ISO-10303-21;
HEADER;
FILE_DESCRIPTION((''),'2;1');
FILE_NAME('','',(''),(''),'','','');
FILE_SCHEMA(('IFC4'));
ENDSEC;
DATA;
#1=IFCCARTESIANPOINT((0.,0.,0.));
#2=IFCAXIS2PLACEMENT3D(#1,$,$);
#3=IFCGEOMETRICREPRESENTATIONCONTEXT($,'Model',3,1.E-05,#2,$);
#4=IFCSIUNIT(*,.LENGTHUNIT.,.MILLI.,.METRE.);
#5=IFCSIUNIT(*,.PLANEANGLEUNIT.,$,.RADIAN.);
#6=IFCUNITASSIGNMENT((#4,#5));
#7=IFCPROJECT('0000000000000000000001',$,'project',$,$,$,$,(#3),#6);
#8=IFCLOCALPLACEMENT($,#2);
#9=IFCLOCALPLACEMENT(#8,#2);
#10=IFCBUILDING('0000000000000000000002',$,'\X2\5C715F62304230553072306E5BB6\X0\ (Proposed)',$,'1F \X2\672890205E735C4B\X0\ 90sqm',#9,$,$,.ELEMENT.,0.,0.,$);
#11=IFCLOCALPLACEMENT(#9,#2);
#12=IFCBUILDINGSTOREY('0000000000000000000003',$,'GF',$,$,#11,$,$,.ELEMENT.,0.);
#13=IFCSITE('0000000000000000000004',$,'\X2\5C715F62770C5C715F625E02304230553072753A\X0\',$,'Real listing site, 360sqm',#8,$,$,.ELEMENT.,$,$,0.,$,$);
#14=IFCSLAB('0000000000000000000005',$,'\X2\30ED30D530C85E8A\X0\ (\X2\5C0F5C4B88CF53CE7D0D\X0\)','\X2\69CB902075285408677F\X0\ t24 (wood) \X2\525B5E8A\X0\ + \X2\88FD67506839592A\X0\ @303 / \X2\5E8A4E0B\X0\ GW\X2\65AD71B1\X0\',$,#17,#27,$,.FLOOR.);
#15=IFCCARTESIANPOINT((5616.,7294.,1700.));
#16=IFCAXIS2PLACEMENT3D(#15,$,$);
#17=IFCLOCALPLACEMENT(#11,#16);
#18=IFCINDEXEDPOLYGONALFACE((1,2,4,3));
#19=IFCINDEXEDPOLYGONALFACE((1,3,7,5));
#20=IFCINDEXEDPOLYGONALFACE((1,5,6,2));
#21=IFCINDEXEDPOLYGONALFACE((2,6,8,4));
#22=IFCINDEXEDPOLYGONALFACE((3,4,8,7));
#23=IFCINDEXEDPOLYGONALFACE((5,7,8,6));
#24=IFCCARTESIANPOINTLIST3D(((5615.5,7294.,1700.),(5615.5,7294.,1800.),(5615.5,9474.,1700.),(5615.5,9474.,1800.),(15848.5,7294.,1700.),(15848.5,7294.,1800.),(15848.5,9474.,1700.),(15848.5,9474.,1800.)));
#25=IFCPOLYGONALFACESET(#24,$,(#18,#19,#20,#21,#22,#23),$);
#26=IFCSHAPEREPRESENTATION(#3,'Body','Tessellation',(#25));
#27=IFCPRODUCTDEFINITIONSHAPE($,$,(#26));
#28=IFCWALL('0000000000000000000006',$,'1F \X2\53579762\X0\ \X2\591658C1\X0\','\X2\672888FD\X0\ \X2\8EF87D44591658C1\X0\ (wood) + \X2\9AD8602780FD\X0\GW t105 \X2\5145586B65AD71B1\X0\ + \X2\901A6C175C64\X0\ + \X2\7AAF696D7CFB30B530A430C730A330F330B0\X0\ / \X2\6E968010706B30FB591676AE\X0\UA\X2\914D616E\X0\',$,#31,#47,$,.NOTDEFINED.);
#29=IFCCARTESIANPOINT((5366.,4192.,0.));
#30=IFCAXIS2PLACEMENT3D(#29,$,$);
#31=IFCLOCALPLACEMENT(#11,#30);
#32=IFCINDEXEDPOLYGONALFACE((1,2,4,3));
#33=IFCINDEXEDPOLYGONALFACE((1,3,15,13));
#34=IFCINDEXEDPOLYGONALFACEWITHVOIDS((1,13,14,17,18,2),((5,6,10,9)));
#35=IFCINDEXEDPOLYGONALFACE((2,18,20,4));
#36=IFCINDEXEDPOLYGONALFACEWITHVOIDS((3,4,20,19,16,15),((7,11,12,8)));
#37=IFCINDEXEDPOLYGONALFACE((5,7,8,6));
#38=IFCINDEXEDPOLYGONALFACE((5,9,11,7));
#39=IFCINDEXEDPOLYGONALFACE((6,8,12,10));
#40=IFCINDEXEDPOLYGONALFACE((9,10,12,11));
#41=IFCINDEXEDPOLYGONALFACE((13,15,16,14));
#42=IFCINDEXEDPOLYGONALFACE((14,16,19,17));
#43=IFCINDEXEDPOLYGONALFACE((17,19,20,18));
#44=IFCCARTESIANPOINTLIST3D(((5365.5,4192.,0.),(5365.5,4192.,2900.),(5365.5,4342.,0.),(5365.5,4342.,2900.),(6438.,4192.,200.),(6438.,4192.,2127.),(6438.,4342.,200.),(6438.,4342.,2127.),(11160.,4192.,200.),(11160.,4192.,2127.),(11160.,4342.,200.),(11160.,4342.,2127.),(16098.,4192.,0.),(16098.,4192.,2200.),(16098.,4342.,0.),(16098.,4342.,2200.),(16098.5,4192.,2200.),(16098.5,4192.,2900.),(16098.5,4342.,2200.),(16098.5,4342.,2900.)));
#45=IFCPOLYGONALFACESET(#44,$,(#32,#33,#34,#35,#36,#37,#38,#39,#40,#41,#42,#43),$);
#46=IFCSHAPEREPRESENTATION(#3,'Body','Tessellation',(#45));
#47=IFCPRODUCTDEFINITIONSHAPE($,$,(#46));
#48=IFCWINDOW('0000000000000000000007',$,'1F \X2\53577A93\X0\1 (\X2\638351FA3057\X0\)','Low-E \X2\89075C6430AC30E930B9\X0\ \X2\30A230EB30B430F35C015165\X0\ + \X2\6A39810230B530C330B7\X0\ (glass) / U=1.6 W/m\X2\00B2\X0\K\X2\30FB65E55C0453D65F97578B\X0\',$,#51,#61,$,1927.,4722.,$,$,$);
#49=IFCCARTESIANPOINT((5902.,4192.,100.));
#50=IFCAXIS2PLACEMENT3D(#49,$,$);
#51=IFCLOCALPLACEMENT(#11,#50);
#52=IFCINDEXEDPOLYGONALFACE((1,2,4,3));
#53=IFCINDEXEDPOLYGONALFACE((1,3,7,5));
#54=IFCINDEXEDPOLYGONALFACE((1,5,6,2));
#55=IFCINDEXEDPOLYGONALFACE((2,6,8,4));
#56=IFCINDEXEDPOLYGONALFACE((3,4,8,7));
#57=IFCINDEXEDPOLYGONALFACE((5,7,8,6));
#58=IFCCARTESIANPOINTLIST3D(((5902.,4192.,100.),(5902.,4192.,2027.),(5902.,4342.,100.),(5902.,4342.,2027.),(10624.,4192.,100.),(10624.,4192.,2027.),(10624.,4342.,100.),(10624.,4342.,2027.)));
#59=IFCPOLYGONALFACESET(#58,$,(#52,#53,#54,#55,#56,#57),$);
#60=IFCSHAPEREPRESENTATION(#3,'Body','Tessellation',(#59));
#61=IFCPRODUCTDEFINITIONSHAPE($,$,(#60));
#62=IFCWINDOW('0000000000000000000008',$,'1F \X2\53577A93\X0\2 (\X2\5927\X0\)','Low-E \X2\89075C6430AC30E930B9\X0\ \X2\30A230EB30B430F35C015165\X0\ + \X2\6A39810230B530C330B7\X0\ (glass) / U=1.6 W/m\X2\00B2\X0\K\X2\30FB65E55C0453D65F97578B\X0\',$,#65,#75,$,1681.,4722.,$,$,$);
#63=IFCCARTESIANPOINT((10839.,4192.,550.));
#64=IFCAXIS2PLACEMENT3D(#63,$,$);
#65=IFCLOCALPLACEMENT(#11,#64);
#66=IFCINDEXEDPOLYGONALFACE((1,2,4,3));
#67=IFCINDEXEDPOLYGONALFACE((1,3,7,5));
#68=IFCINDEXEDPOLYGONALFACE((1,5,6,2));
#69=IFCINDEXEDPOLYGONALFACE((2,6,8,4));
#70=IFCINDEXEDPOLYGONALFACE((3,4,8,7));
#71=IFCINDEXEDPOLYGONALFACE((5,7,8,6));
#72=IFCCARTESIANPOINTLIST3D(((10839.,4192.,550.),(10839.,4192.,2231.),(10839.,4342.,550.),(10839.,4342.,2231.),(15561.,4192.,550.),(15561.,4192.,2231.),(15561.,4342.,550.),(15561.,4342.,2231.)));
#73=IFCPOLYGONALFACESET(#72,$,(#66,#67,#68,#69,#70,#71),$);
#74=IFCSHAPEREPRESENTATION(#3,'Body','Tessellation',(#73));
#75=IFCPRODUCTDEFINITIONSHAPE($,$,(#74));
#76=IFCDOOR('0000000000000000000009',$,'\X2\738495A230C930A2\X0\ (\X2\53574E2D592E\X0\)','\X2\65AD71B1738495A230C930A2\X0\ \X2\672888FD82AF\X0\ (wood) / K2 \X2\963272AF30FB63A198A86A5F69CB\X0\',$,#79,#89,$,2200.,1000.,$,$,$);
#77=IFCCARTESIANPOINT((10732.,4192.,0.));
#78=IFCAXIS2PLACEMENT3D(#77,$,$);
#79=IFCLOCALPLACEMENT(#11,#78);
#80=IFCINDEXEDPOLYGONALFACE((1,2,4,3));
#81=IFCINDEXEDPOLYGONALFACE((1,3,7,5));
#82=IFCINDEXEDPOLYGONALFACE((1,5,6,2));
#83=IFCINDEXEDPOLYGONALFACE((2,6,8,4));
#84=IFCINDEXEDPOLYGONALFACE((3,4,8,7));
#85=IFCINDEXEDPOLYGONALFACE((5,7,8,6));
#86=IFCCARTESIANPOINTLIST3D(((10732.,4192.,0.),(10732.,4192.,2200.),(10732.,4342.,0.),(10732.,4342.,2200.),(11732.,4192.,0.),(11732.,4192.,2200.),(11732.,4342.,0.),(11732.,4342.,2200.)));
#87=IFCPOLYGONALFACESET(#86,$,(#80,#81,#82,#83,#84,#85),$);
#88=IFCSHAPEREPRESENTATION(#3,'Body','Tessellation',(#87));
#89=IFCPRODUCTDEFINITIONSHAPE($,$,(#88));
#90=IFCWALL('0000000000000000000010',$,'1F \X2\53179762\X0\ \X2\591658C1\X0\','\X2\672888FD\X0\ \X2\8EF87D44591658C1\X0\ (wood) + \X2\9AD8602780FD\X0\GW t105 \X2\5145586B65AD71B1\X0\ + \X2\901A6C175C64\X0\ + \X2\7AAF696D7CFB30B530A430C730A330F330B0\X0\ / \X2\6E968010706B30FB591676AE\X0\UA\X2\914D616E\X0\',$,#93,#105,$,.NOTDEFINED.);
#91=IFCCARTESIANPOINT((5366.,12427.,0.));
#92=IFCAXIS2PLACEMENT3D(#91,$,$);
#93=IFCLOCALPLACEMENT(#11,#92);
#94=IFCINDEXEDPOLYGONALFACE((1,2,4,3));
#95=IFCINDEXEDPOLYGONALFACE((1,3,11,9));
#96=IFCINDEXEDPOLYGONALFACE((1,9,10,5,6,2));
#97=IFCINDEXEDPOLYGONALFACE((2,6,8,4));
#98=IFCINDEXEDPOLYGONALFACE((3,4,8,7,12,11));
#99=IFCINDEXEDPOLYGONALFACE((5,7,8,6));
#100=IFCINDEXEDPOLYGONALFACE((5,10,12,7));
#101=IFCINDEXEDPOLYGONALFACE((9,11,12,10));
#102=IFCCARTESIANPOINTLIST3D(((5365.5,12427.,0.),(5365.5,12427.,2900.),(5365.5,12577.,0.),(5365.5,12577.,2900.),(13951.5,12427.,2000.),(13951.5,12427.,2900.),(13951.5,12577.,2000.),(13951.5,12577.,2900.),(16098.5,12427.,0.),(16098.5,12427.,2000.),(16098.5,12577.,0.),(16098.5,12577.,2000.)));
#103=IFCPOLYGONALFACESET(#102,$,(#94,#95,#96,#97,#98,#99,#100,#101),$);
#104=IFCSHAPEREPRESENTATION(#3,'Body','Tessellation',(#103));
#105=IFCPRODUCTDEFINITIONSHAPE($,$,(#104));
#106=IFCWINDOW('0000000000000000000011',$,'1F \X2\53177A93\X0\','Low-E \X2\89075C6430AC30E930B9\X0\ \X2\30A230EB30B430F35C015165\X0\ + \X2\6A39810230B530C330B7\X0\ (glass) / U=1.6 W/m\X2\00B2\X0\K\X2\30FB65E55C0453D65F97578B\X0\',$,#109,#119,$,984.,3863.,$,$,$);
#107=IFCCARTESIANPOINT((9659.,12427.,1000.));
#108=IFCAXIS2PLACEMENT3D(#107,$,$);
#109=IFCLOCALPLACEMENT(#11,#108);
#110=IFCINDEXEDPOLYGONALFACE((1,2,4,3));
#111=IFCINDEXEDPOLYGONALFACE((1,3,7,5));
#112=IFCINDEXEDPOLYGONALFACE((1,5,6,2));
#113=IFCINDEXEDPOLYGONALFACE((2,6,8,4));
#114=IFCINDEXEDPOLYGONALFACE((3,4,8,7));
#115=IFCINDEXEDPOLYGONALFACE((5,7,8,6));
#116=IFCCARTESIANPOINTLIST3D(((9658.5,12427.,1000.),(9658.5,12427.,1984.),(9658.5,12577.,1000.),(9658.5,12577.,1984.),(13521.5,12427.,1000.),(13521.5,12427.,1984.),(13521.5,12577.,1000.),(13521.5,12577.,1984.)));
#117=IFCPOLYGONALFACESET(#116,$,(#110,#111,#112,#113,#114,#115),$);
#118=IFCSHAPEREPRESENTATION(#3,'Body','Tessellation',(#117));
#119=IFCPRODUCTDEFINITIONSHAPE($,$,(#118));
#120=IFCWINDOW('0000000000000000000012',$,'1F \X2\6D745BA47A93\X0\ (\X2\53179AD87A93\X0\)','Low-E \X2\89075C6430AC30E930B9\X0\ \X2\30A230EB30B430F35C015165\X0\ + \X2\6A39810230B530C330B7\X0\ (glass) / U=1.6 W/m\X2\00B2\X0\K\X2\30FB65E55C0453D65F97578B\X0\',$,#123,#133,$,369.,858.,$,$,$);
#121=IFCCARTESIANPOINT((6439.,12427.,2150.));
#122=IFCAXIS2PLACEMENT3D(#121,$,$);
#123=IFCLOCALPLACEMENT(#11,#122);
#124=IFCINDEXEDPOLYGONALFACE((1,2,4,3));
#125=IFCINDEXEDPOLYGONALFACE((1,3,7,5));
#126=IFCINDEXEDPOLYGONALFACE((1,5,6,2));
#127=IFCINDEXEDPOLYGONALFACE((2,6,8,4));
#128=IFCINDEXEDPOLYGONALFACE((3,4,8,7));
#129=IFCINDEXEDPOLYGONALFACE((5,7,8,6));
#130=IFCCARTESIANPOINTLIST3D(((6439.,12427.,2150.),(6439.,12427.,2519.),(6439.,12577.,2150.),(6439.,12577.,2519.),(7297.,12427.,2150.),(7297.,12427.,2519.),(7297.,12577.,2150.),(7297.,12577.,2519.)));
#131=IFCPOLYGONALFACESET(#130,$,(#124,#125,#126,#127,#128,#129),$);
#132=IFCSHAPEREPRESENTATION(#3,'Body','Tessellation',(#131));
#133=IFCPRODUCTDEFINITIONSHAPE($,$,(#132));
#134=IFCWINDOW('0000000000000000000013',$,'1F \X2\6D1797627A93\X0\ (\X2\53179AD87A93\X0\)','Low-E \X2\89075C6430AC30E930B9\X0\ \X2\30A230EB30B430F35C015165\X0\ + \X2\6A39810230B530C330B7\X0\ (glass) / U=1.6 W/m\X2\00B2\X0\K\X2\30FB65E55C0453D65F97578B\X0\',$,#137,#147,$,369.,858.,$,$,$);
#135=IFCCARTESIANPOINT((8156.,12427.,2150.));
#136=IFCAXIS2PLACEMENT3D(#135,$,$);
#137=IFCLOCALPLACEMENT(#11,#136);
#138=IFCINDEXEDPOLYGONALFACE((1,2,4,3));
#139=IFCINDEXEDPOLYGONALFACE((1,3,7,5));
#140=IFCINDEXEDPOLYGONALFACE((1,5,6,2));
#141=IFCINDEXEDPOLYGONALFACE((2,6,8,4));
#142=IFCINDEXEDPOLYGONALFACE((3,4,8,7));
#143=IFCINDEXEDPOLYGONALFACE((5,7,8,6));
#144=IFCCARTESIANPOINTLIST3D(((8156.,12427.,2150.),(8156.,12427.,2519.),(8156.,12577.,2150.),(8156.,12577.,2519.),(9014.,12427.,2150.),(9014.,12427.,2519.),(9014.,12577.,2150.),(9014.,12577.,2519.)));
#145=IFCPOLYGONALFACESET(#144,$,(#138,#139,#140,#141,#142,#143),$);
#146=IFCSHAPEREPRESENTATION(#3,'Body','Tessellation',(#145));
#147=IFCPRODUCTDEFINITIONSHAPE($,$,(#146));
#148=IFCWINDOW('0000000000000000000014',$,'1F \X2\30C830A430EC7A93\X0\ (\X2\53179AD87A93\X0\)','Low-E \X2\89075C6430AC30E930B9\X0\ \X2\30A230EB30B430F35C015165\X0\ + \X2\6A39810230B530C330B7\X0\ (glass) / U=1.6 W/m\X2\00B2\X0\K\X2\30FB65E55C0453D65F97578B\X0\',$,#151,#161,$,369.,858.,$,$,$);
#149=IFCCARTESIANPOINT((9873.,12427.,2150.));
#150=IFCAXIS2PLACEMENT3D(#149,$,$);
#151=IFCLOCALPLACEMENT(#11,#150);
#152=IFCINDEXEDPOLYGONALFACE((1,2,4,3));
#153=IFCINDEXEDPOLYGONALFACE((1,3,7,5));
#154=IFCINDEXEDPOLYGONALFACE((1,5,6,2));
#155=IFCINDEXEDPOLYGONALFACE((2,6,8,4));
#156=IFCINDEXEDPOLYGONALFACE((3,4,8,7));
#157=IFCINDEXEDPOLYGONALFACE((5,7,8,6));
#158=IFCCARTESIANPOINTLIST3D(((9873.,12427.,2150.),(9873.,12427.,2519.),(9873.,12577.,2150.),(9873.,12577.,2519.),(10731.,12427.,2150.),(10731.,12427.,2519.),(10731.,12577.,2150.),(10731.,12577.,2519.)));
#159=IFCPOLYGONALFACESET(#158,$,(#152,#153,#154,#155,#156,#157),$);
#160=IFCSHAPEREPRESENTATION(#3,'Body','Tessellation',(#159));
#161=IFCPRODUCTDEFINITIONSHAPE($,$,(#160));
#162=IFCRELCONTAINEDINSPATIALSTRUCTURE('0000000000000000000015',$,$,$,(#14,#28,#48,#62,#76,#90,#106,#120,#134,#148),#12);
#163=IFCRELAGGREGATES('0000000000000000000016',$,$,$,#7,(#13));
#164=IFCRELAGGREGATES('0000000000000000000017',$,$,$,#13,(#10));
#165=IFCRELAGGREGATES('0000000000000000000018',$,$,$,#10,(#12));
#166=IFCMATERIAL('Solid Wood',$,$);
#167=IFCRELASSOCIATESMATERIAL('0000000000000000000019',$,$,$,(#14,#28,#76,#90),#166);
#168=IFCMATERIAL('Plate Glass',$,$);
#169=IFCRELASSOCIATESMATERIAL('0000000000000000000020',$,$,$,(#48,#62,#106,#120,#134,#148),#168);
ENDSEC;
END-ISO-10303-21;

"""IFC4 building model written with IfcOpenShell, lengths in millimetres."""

from ifc_helpers import new_model, si_unit, frame, frame_2d, origin, place, context, project, spatial, rectangle, extrude, material, element, fill, save


model = new_model("IFC4")

# Units and contexts
model_context = context("Model", 3, precision=1e-05, world=origin())
ifc_project = project(units=[si_unit("LENGTHUNIT", "METRE", prefix="MILLI"), si_unit("PLANEANGLEUNIT", "RADIAN")], contexts=[model_context])

# Site, building, storey
site_placement = place(None, origin())
site = spatial("IfcSite", under=ifc_project, at=site_placement, Name="山形県山形市あさひ町", ObjectType="Real listing site, 360sqm", CompositionType="ELEMENT", RefElevation=0.0)
building_placement = place(site_placement, origin())
building = spatial("IfcBuilding", under=site, at=building_placement, Name="山形あさひの家 (Proposed)", ObjectType="1F 木造平屋 90sqm", CompositionType="ELEMENT", ElevationOfRefHeight=0.0, ElevationOfTerrain=0.0)
storey_placement = place(building_placement, origin())
storey = spatial("IfcBuildingStorey", under=building, at=storey_placement, Name="GF", CompositionType="ELEMENT", Elevation=0.0)

# Slab
ifc_material_1 = material(Name="Solid Wood")
slab_1_placement = place(storey_placement, frame((5616.0, 7294.0, 1700.0)))
element("IfcSlab", 1, at=slab_1_placement, inside=storey, material=ifc_material_1, Name="ロフト床 (小屋裏収納)", Description="構造用合板 t24 (wood) 剛床 + 製材根太 @303 / 床下 GW断熱", PredefinedType="FLOOR", context=model_context, shape_type="SweptSolid", body=[
    extrude(rectangle(XDim=10233.0, YDim=2180.0, at=frame_2d((5116.0, 1090.0))), frame((5616.0, 7294.0, 1700.0)), (0.0, 0.0, 1.0), 100.0),
])

# Wall, openings, windows, door
wall_1_placement = place(storey_placement, frame((5366.0, 4192.0, 0.0)))
wall_1 = element("IfcWall", 2, at=wall_1_placement, inside=storey, material=ifc_material_1, Name="1F 南面 外壁", Description="木製 軸組外壁 (wood) + 高性能GW t105 充填断熱 + 通気層 + 窯業系サイディング / 準耐火・外皮UA配慮", PredefinedType="NOTDEFINED", context=model_context, shape_type="SweptSolid", body=[
    extrude(rectangle(XDim=10733.0, YDim=150.0, at=frame_2d((5366.0, 75.0))), frame((5366.0, 4192.0, 0.0)), (0.0, 0.0, 1.0), 2900.0),
])
opening_1_placement = place(storey_placement, frame((5902.0, 4192.0, 100.0)))
opening_1 = element("IfcOpeningElement", 3, at=opening_1_placement, cuts=wall_1, PredefinedType="NOTDEFINED", context=model_context, shape_type="SweptSolid", body=[
    extrude(rectangle(XDim=4722.0, YDim=150.0, at=frame_2d((2361.0, 75.0))), frame((5902.0, 4192.0, 100.0)), (0.0, 0.0, 1.0), 1927.0),
])
opening_2_placement = place(storey_placement, frame((10839.0, 4192.0, 550.0)))
opening_2 = element("IfcOpeningElement", 4, at=opening_2_placement, cuts=wall_1, PredefinedType="NOTDEFINED", context=model_context, shape_type="SweptSolid", body=[
    extrude(rectangle(XDim=4722.0, YDim=150.0, at=frame_2d((2361.0, 75.0))), frame((10839.0, 4192.0, 550.0)), (0.0, 0.0, 1.0), 1681.0),
])
opening_3_placement = place(storey_placement, frame((10732.0, 4192.0, 0.0)))
opening_3 = element("IfcOpeningElement", 5, at=opening_3_placement, cuts=wall_1, PredefinedType="NOTDEFINED", context=model_context, shape_type="SweptSolid", body=[
    extrude(rectangle(XDim=1000.0, YDim=150.0, at=frame_2d((500.0, 75.0))), frame((10732.0, 4192.0, 0.0)), (0.0, 0.0, 1.0), 2200.0),
])
ifc_material_2 = material(Name="Plate Glass")
window_1_placement = place(storey_placement, frame((5902.0, 4192.0, 100.0)))
window_1 = element("IfcWindow", 6, at=window_1_placement, inside=storey, material=ifc_material_2, Name="1F 南窓1 (掃出し)", Description="Low-E 複層ガラス アルゴン封入 + 樹脂サッシ (glass) / U=1.6 W/m²K・日射取得型", OverallHeight=1927.0, OverallWidth=4722.0, context=model_context, shape_type="SweptSolid", body=[
    extrude(rectangle(XDim=4722.0, YDim=150.0, at=frame_2d((2361.0, 75.0))), frame((5902.0, 4192.0, 100.0)), (0.0, 0.0, 1.0), 1927.0),
])
fill(opening_1, window_1)
window_2_placement = place(storey_placement, frame((10839.0, 4192.0, 550.0)))
window_2 = element("IfcWindow", 7, at=window_2_placement, inside=storey, material=ifc_material_2, Name="1F 南窓2 (大)", Description="Low-E 複層ガラス アルゴン封入 + 樹脂サッシ (glass) / U=1.6 W/m²K・日射取得型", OverallHeight=1681.0, OverallWidth=4722.0, context=model_context, shape_type="SweptSolid", body=[
    extrude(rectangle(XDim=4722.0, YDim=150.0, at=frame_2d((2361.0, 75.0))), frame((10839.0, 4192.0, 550.0)), (0.0, 0.0, 1.0), 1681.0),
])
fill(opening_2, window_2)
door_1_placement = place(storey_placement, frame((10732.0, 4192.0, 0.0)))
door_1 = element("IfcDoor", 8, at=door_1_placement, inside=storey, material=ifc_material_1, Name="玄関ドア (南中央)", Description="断熱玄関ドア 木製芯 (wood) / K2 防犯・採風機構", OverallHeight=2200.0, OverallWidth=1000.0, context=model_context, shape_type="SweptSolid", body=[
    extrude(rectangle(XDim=1000.0, YDim=150.0, at=frame_2d((500.0, 75.0))), frame((10732.0, 4192.0, 0.0)), (0.0, 0.0, 1.0), 2200.0),
])
fill(opening_3, door_1)

# Wall, openings, windows
wall_2_placement = place(storey_placement, frame((5366.0, 12427.0, 0.0)))
wall_2 = element("IfcWall", 9, at=wall_2_placement, inside=storey, material=ifc_material_1, Name="1F 北面 外壁", Description="木製 軸組外壁 (wood) + 高性能GW t105 充填断熱 + 通気層 + 窯業系サイディング / 準耐火・外皮UA配慮", PredefinedType="NOTDEFINED", context=model_context, shape_type="SweptSolid", body=[
    extrude(rectangle(XDim=10733.0, YDim=150.0, at=frame_2d((5366.0, 75.0))), frame((5366.0, 12427.0, 0.0)), (0.0, 0.0, 1.0), 2900.0),
])
opening_4_placement = place(storey_placement, frame((9659.0, 12427.0, 1000.0)))
opening_4 = element("IfcOpeningElement", 10, at=opening_4_placement, cuts=wall_2, PredefinedType="NOTDEFINED", context=model_context, shape_type="SweptSolid", body=[
    extrude(rectangle(XDim=3863.0, YDim=150.0, at=frame_2d((1931.0, 75.0))), frame((9659.0, 12427.0, 1000.0)), (0.0, 0.0, 1.0), 984.0),
])
opening_5_placement = place(storey_placement, frame((6439.0, 12427.0, 2150.0)))
opening_5 = element("IfcOpeningElement", 11, at=opening_5_placement, cuts=wall_2, PredefinedType="NOTDEFINED", context=model_context, shape_type="SweptSolid", body=[
    extrude(rectangle(XDim=858.0, YDim=150.0, at=frame_2d((429.0, 75.0))), frame((6439.0, 12427.0, 2150.0)), (0.0, 0.0, 1.0), 369.0),
])
opening_6_placement = place(storey_placement, frame((8156.0, 12427.0, 2150.0)))
opening_6 = element("IfcOpeningElement", 12, at=opening_6_placement, cuts=wall_2, PredefinedType="NOTDEFINED", context=model_context, shape_type="SweptSolid", body=[
    extrude(rectangle(XDim=858.0, YDim=150.0, at=frame_2d((429.0, 75.0))), frame((8156.0, 12427.0, 2150.0)), (0.0, 0.0, 1.0), 369.0),
])
opening_7_placement = place(storey_placement, frame((9873.0, 12427.0, 2150.0)))
opening_7 = element("IfcOpeningElement", 13, at=opening_7_placement, cuts=wall_2, PredefinedType="NOTDEFINED", context=model_context, shape_type="SweptSolid", body=[
    extrude(rectangle(XDim=858.0, YDim=150.0, at=frame_2d((429.0, 75.0))), frame((9873.0, 12427.0, 2150.0)), (0.0, 0.0, 1.0), 369.0),
])
window_3_placement = place(storey_placement, frame((9659.0, 12427.0, 1000.0)))
window_3 = element("IfcWindow", 14, at=window_3_placement, inside=storey, material=ifc_material_2, Name="1F 北窓", Description="Low-E 複層ガラス アルゴン封入 + 樹脂サッシ (glass) / U=1.6 W/m²K・日射取得型", OverallHeight=984.0, OverallWidth=3863.0, context=model_context, shape_type="SweptSolid", body=[
    extrude(rectangle(XDim=3863.0, YDim=150.0, at=frame_2d((1931.0, 75.0))), frame((9659.0, 12427.0, 1000.0)), (0.0, 0.0, 1.0), 984.0),
])
fill(opening_4, window_3)
window_4_placement = place(storey_placement, frame((6439.0, 12427.0, 2150.0)))
window_4 = element("IfcWindow", 15, at=window_4_placement, inside=storey, material=ifc_material_2, Name="1F 浴室窓 (北高窓)", Description="Low-E 複層ガラス アルゴン封入 + 樹脂サッシ (glass) / U=1.6 W/m²K・日射取得型", OverallHeight=369.0, OverallWidth=858.0, context=model_context, shape_type="SweptSolid", body=[
    extrude(rectangle(XDim=858.0, YDim=150.0, at=frame_2d((429.0, 75.0))), frame((6439.0, 12427.0, 2150.0)), (0.0, 0.0, 1.0), 369.0),
])
fill(opening_5, window_4)
window_5_placement = place(storey_placement, frame((8156.0, 12427.0, 2150.0)))
window_5 = element("IfcWindow", 16, at=window_5_placement, inside=storey, material=ifc_material_2, Name="1F 洗面窓 (北高窓)", Description="Low-E 複層ガラス アルゴン封入 + 樹脂サッシ (glass) / U=1.6 W/m²K・日射取得型", OverallHeight=369.0, OverallWidth=858.0, context=model_context, shape_type="SweptSolid", body=[
    extrude(rectangle(XDim=858.0, YDim=150.0, at=frame_2d((429.0, 75.0))), frame((8156.0, 12427.0, 2150.0)), (0.0, 0.0, 1.0), 369.0),
])
fill(opening_6, window_5)
window_6_placement = place(storey_placement, frame((9873.0, 12427.0, 2150.0)))
window_6 = element("IfcWindow", 17, at=window_6_placement, inside=storey, material=ifc_material_2, Name="1F トイレ窓 (北高窓)", Description="Low-E 複層ガラス アルゴン封入 + 樹脂サッシ (glass) / U=1.6 W/m²K・日射取得型", OverallHeight=369.0, OverallWidth=858.0, context=model_context, shape_type="SweptSolid", body=[
    extrude(rectangle(XDim=858.0, YDim=150.0, at=frame_2d((429.0, 75.0))), frame((9873.0, 12427.0, 2150.0)), (0.0, 0.0, 1.0), 369.0),
])
fill(opening_7, window_6)

save(model, "model.ifc")
